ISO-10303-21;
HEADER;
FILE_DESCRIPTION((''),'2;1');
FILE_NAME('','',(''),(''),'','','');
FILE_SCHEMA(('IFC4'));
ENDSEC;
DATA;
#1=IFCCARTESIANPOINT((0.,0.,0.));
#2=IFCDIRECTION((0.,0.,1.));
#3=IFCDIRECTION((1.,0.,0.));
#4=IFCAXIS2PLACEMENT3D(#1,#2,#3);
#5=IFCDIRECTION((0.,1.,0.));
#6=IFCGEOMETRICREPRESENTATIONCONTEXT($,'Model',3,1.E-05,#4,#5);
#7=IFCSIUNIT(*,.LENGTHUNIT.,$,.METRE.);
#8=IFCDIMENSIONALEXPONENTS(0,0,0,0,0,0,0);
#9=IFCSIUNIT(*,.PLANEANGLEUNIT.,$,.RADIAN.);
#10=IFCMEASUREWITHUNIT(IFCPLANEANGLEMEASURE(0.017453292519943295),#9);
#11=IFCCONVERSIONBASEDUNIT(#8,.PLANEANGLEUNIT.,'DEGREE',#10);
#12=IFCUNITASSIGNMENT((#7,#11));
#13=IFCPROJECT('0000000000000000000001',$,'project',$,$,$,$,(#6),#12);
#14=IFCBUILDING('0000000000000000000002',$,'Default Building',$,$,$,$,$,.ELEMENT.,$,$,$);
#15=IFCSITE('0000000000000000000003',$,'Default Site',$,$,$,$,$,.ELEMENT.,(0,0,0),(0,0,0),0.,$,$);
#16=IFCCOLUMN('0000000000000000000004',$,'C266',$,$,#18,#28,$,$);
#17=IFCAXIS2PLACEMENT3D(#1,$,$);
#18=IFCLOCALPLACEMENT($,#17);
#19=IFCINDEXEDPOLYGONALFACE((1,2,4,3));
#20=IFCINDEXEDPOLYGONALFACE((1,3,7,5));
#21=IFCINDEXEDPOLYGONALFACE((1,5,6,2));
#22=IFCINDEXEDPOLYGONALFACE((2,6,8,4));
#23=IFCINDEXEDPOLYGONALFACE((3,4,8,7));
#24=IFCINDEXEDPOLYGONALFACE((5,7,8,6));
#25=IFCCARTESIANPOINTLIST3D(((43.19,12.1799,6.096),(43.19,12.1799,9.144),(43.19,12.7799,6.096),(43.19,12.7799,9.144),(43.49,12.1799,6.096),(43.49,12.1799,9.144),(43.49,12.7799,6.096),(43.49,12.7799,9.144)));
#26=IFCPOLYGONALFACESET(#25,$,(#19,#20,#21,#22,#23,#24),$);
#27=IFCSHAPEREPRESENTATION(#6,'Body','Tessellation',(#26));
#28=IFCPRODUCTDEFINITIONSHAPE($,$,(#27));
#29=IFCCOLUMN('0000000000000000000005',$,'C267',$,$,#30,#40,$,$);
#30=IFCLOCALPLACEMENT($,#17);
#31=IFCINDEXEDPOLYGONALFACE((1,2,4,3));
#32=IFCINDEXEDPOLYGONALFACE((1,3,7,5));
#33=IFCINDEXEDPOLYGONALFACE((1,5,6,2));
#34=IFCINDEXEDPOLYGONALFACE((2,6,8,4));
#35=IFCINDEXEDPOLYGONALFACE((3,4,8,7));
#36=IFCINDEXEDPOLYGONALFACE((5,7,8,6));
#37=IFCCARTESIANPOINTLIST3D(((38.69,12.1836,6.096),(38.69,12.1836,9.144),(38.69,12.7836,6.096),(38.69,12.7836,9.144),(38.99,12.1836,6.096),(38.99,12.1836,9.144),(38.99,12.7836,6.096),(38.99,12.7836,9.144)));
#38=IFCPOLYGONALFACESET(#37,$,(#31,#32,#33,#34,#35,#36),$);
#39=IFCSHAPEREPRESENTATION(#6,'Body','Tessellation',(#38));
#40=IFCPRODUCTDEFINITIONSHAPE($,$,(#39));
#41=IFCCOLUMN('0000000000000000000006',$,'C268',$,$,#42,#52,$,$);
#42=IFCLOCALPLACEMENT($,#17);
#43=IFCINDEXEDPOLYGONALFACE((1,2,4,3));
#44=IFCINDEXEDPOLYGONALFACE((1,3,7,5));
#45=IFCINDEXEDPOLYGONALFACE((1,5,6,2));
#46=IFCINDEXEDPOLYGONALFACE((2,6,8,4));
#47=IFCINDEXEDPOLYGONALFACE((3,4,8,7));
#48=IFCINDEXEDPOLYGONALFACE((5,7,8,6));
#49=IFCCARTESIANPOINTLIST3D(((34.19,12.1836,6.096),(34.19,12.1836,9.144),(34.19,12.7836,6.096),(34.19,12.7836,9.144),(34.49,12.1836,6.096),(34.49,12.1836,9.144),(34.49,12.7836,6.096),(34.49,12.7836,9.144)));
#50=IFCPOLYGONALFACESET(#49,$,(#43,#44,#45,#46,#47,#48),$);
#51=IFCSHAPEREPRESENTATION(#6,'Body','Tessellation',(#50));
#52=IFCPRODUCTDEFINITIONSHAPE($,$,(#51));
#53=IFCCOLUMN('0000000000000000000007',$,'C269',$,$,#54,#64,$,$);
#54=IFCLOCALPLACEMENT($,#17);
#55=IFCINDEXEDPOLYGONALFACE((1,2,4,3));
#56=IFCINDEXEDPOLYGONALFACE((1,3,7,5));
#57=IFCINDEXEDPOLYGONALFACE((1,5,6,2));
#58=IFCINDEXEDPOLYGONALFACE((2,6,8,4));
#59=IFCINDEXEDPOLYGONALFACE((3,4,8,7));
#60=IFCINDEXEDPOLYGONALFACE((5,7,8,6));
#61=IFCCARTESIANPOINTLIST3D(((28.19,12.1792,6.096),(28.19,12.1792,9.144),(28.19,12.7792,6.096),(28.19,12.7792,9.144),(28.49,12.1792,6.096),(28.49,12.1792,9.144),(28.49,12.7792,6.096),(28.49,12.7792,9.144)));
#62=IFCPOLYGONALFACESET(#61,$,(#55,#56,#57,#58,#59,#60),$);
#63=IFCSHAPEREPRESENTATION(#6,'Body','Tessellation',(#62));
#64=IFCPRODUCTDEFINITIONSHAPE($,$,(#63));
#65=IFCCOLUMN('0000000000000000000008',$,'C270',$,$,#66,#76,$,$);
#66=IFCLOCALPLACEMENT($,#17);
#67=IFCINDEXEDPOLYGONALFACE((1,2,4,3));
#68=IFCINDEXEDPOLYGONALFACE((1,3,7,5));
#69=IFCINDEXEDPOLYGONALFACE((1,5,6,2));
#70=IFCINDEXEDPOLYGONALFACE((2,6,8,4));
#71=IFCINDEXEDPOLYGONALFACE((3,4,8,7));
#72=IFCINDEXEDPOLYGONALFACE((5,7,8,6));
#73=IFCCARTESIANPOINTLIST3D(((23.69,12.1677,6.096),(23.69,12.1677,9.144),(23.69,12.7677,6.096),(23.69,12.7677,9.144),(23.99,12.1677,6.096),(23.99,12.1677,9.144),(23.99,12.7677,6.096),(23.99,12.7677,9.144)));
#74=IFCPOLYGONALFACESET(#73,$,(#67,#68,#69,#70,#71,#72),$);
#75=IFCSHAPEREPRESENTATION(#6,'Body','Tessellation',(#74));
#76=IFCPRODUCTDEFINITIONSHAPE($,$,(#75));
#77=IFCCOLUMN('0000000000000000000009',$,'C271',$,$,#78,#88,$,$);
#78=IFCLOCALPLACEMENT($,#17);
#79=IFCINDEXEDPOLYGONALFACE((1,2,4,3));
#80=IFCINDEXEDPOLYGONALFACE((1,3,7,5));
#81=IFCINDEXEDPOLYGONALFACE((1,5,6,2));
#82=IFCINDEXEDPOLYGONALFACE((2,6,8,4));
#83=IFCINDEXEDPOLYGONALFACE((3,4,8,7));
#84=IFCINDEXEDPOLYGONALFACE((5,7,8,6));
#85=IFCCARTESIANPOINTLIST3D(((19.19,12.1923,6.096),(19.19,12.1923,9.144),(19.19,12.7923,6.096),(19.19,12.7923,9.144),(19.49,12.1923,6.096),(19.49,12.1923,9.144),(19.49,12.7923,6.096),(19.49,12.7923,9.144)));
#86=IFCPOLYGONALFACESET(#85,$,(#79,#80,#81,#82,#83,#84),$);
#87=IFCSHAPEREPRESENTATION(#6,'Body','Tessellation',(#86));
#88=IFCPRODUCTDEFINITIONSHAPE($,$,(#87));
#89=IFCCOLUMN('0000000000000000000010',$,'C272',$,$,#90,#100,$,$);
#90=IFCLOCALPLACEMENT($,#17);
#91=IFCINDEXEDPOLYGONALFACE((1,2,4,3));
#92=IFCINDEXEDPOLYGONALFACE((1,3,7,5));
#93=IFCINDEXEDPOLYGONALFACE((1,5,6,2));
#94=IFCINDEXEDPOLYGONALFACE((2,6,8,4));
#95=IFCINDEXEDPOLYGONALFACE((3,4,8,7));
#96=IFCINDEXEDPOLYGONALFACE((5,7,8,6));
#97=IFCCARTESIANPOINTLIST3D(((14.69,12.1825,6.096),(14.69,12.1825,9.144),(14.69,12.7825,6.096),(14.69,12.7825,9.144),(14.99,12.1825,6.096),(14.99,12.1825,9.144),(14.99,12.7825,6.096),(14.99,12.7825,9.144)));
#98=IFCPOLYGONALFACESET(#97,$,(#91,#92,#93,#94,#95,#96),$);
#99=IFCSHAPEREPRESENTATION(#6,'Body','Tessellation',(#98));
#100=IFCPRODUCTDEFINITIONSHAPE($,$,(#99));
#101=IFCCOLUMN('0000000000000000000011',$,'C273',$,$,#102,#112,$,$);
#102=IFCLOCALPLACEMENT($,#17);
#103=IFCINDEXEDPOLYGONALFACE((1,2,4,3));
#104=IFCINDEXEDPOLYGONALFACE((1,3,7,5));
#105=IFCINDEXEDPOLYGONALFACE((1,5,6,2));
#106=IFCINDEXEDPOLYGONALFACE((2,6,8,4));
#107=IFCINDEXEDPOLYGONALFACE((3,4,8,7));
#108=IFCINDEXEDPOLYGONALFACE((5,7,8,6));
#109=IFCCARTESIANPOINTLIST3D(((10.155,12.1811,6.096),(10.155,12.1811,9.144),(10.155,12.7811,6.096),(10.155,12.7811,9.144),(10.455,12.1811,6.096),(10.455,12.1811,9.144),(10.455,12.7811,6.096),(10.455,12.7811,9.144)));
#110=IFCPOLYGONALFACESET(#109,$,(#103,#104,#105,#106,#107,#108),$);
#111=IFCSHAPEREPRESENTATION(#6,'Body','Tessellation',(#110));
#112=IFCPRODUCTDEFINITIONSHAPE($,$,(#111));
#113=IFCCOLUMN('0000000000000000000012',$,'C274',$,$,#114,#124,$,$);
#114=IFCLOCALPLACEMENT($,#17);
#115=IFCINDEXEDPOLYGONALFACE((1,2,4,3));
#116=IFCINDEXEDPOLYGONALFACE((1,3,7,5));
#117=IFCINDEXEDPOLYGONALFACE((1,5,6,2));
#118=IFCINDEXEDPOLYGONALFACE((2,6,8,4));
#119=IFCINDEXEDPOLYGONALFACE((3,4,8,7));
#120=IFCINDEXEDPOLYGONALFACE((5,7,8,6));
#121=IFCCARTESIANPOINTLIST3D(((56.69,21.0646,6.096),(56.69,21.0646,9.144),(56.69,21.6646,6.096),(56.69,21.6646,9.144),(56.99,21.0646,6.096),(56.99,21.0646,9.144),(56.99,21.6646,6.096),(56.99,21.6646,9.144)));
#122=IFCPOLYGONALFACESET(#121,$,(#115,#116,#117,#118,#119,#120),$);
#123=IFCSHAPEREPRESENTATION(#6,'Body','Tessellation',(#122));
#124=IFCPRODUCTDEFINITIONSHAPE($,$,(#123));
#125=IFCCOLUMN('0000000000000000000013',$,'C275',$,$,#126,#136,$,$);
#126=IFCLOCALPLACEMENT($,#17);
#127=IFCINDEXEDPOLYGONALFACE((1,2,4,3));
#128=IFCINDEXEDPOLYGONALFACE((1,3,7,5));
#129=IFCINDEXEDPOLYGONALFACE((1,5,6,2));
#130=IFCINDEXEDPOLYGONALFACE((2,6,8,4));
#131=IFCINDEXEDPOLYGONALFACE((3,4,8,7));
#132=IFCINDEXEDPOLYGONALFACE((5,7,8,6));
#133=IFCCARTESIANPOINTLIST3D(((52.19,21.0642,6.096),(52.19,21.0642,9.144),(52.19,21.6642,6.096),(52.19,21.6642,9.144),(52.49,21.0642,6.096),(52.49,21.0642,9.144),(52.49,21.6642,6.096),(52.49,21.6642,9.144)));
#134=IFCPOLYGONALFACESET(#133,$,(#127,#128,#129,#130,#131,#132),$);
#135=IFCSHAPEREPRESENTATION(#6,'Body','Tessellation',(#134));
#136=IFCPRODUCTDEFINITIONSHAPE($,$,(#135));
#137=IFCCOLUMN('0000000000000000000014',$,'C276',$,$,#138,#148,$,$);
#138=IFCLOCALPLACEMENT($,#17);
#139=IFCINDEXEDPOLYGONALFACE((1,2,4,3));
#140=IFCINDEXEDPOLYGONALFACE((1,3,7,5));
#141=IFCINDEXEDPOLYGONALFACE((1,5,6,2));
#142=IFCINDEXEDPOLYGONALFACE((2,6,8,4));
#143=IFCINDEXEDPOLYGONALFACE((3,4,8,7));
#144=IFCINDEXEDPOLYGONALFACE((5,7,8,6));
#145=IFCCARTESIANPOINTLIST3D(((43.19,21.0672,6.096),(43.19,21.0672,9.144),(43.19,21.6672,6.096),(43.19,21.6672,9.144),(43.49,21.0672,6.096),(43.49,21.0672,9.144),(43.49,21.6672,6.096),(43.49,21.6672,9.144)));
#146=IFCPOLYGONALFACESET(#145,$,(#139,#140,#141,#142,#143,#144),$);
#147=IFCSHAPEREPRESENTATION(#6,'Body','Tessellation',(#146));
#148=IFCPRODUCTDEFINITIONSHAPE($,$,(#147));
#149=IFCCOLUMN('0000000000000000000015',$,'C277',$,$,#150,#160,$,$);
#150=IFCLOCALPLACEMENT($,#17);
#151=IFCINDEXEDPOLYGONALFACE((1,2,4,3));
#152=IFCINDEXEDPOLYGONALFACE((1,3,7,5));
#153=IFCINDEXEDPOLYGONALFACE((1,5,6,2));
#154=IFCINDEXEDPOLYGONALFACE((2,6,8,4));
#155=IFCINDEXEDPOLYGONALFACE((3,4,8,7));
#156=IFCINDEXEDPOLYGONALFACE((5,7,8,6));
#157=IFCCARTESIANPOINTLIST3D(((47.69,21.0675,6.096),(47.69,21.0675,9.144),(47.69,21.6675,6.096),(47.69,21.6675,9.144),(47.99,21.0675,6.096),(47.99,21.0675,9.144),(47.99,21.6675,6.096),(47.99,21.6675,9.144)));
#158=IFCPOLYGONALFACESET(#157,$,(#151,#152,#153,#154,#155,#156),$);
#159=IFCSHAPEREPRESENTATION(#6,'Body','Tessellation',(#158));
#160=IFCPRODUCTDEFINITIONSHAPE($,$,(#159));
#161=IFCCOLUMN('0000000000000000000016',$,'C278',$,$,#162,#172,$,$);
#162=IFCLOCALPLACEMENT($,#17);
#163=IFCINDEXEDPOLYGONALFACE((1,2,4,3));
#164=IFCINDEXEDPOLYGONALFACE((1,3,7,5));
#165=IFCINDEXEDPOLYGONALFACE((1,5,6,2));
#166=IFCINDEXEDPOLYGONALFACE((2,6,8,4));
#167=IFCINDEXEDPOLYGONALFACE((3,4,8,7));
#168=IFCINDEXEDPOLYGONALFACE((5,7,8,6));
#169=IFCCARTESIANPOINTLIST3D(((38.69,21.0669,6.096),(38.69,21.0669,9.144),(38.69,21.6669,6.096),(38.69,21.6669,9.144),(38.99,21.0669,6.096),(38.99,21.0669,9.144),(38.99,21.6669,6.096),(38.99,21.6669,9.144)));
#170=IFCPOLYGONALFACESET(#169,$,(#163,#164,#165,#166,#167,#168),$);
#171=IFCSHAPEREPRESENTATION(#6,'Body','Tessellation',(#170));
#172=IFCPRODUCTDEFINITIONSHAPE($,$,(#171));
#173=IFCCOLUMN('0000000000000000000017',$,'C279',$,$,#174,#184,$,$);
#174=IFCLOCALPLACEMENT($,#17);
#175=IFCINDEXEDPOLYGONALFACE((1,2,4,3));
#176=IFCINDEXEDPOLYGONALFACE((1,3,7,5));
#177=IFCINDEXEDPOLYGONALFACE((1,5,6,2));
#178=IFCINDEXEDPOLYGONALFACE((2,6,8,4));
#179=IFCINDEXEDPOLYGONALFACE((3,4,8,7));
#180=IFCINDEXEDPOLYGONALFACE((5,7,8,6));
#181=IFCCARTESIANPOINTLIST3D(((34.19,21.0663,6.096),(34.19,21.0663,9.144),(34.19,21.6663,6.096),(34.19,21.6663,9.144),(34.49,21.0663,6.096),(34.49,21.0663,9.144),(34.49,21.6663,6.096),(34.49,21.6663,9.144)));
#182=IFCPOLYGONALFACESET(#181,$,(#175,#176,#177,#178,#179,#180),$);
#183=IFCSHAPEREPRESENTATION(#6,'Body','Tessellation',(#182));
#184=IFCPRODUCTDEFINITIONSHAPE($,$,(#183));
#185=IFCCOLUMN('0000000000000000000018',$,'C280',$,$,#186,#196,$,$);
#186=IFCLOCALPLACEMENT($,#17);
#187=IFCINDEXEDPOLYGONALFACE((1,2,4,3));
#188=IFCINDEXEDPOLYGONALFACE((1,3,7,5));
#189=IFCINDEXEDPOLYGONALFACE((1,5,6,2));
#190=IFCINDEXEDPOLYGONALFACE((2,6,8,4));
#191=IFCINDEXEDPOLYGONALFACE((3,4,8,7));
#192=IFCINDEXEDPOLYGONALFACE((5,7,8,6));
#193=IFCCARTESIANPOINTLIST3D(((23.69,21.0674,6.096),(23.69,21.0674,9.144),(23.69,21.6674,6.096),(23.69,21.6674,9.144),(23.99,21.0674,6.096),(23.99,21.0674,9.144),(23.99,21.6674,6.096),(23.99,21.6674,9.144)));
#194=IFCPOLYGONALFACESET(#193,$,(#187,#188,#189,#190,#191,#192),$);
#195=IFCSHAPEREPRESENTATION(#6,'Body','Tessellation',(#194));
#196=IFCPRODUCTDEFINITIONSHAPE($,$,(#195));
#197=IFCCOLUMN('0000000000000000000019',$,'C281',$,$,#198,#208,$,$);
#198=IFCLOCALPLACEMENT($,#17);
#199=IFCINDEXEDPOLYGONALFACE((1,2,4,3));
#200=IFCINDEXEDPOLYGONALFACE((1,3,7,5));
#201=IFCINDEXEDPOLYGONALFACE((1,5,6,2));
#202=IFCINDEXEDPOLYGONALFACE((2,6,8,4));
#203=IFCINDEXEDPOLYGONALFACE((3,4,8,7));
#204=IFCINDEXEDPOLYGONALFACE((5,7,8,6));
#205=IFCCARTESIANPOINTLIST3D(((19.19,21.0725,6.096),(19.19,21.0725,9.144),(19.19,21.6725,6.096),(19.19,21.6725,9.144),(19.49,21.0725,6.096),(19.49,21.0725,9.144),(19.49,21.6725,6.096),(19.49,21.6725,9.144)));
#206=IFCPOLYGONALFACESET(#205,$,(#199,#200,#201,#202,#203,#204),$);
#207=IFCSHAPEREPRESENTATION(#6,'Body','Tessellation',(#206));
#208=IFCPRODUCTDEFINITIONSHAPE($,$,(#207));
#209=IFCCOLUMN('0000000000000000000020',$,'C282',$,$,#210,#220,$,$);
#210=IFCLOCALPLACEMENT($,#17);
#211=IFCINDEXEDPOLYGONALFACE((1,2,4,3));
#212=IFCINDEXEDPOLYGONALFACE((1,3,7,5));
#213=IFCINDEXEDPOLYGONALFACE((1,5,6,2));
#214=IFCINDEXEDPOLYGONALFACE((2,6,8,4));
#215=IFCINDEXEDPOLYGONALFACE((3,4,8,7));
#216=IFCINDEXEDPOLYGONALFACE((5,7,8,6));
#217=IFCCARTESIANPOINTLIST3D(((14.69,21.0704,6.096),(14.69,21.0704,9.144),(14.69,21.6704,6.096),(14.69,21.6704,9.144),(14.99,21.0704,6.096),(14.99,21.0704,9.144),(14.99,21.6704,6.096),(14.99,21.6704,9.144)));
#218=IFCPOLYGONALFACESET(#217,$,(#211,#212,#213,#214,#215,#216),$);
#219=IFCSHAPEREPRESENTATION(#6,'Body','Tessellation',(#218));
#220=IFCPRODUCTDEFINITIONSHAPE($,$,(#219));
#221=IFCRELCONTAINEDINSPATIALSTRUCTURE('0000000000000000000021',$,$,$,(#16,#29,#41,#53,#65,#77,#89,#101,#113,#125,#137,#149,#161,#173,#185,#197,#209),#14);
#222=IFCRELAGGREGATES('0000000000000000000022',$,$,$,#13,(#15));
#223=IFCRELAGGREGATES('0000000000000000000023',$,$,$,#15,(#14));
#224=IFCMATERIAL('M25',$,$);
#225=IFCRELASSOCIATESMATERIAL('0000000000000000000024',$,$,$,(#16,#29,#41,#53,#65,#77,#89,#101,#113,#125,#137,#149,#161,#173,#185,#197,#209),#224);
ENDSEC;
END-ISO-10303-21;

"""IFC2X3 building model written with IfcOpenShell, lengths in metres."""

from ifc_helpers import new_model, entity, si_unit, converted_unit, direction, frame, frame_2d, origin_with_axes, place, context, project, spatial, rectangle, extrude, material, element, save


model = new_model("IFC2X3")

# Units and contexts
model_context = context("Model", 3, precision=1e-05, world=origin_with_axes(), true_north=direction((0.0, 1.0, 0.0)))
ifc_project = project(units=[si_unit("LENGTHUNIT", "METRE"), converted_unit("PLANEANGLEUNIT", "DEGREE", entity("IfcPlaneAngleMeasure", 0.017453292519943295), si_unit("PLANEANGLEUNIT", "RADIAN"), dimensions=[0, 0, 0, 0, 0, 0, 0])], contexts=[model_context])

# Site, building
site = spatial("IfcSite", under=ifc_project, Name="Default Site", CompositionType="ELEMENT", RefLatitude=(0, 0, 0), RefLongitude=(0, 0, 0), RefElevation=0.0)
building = spatial("IfcBuilding", under=site, Name="Default Building", CompositionType="ELEMENT")

# Columns
ifc_material = material(Name="M25")
placement = place(None, origin_with_axes())
element("IfcColumn", 1, at=placement, inside=building, material=ifc_material, Name="C266", context=model_context, shape_type="SweptSolid", body=[
    extrude(rectangle(XDim=0.3, YDim=0.6, at=frame_2d((0.0, 0.0), x_axis=(1.0, 0.0, 0.0))), frame((43.34, 12.4799, 6.096), z_axis=(0.0, 0.0, 1.0), x_axis=(1.0, 0.0, 0.0)), (0.0, 0.0, 1.0), 3.048),
])
element("IfcColumn", 2, at=placement, inside=building, material=ifc_material, Name="C267", context=model_context, shape_type="SweptSolid", body=[
    extrude(rectangle(XDim=0.3, YDim=0.6, at=frame_2d((0.0, 0.0), x_axis=(1.0, 0.0, 0.0))), frame((38.84, 12.4836, 6.096), z_axis=(0.0, 0.0, 1.0), x_axis=(1.0, 0.0, 0.0)), (0.0, 0.0, 1.0), 3.048),
])
element("IfcColumn", 3, at=placement, inside=building, material=ifc_material, Name="C268", context=model_context, shape_type="SweptSolid", body=[
    extrude(rectangle(XDim=0.3, YDim=0.6, at=frame_2d((0.0, 0.0), x_axis=(1.0, 0.0, 0.0))), frame((34.34, 12.4836, 6.096), z_axis=(0.0, 0.0, 1.0), x_axis=(1.0, 0.0, 0.0)), (0.0, 0.0, 1.0), 3.048),
])
element("IfcColumn", 4, at=placement, inside=building, material=ifc_material, Name="C269", context=model_context, shape_type="SweptSolid", body=[
    extrude(rectangle(XDim=0.3, YDim=0.6, at=frame_2d((0.0, 0.0), x_axis=(1.0, 0.0, 0.0))), frame((28.34, 12.4792, 6.096), z_axis=(0.0, 0.0, 1.0), x_axis=(1.0, 0.0, 0.0)), (0.0, 0.0, 1.0), 3.048),
])
element("IfcColumn", 5, at=placement, inside=building, material=ifc_material, Name="C270", context=model_context, shape_type="SweptSolid", body=[
    extrude(rectangle(XDim=0.3, YDim=0.6, at=frame_2d((0.0, 0.0), x_axis=(1.0, 0.0, 0.0))), frame((23.84, 12.4677, 6.096), z_axis=(0.0, 0.0, 1.0), x_axis=(1.0, 0.0, 0.0)), (0.0, 0.0, 1.0), 3.048),
])
element("IfcColumn", 6, at=placement, inside=building, material=ifc_material, Name="C271", context=model_context, shape_type="SweptSolid", body=[
    extrude(rectangle(XDim=0.3, YDim=0.6, at=frame_2d((0.0, 0.0), x_axis=(1.0, 0.0, 0.0))), frame((19.34, 12.4923, 6.096), z_axis=(0.0, 0.0, 1.0), x_axis=(1.0, 0.0, 0.0)), (0.0, 0.0, 1.0), 3.048),
])
element("IfcColumn", 7, at=placement, inside=building, material=ifc_material, Name="C272", context=model_context, shape_type="SweptSolid", body=[
    extrude(rectangle(XDim=0.3, YDim=0.6, at=frame_2d((0.0, 0.0), x_axis=(1.0, 0.0, 0.0))), frame((14.84, 12.4825, 6.096), z_axis=(0.0, 0.0, 1.0), x_axis=(1.0, 0.0, 0.0)), (0.0, 0.0, 1.0), 3.048),
])
element("IfcColumn", 8, at=placement, inside=building, material=ifc_material, Name="C273", context=model_context, shape_type="SweptSolid", body=[
    extrude(rectangle(XDim=0.3, YDim=0.6, at=frame_2d((0.0, 0.0), x_axis=(1.0, 0.0, 0.0))), frame((10.305, 12.4811, 6.096), z_axis=(0.0, 0.0, 1.0), x_axis=(1.0, 0.0, 0.0)), (0.0, 0.0, 1.0), 3.048),
])
element("IfcColumn", 9, at=placement, inside=building, material=ifc_material, Name="C274", context=model_context, shape_type="SweptSolid", body=[
    extrude(rectangle(XDim=0.3, YDim=0.6, at=frame_2d((0.0, 0.0), x_axis=(1.0, 0.0, 0.0))), frame((56.84, 21.3646, 6.096), z_axis=(0.0, 0.0, 1.0), x_axis=(1.0, 0.0, 0.0)), (0.0, 0.0, 1.0), 3.048),
])
element("IfcColumn", 10, at=placement, inside=building, material=ifc_material, Name="C275", context=model_context, shape_type="SweptSolid", body=[
    extrude(rectangle(XDim=0.3, YDim=0.6, at=frame_2d((0.0, 0.0), x_axis=(1.0, 0.0, 0.0))), frame((52.34, 21.3642, 6.096), z_axis=(0.0, 0.0, 1.0), x_axis=(1.0, 0.0, 0.0)), (0.0, 0.0, 1.0), 3.048),
])
element("IfcColumn", 11, at=placement, inside=building, material=ifc_material, Name="C276", context=model_context, shape_type="SweptSolid", body=[
    extrude(rectangle(XDim=0.3, YDim=0.6, at=frame_2d((0.0, 0.0), x_axis=(1.0, 0.0, 0.0))), frame((43.34, 21.3672, 6.096), z_axis=(0.0, 0.0, 1.0), x_axis=(1.0, 0.0, 0.0)), (0.0, 0.0, 1.0), 3.048),
])
element("IfcColumn", 12, at=placement, inside=building, material=ifc_material, Name="C277", context=model_context, shape_type="SweptSolid", body=[
    extrude(rectangle(XDim=0.3, YDim=0.6, at=frame_2d((0.0, 0.0), x_axis=(1.0, 0.0, 0.0))), frame((47.84, 21.3675, 6.096), z_axis=(0.0, 0.0, 1.0), x_axis=(1.0, 0.0, 0.0)), (0.0, 0.0, 1.0), 3.048),
])
element("IfcColumn", 13, at=placement, inside=building, material=ifc_material, Name="C278", context=model_context, shape_type="SweptSolid", body=[
    extrude(rectangle(XDim=0.3, YDim=0.6, at=frame_2d((0.0, 0.0), x_axis=(1.0, 0.0, 0.0))), frame((38.84, 21.3669, 6.096), z_axis=(0.0, 0.0, 1.0), x_axis=(1.0, 0.0, 0.0)), (0.0, 0.0, 1.0), 3.048),
])
element("IfcColumn", 14, at=placement, inside=building, material=ifc_material, Name="C279", context=model_context, shape_type="SweptSolid", body=[
    extrude(rectangle(XDim=0.3, YDim=0.6, at=frame_2d((0.0, 0.0), x_axis=(1.0, 0.0, 0.0))), frame((34.34, 21.3663, 6.096), z_axis=(0.0, 0.0, 1.0), x_axis=(1.0, 0.0, 0.0)), (0.0, 0.0, 1.0), 3.048),
])
element("IfcColumn", 15, at=placement, inside=building, material=ifc_material, Name="C280", context=model_context, shape_type="SweptSolid", body=[
    extrude(rectangle(XDim=0.3, YDim=0.6, at=frame_2d((0.0, 0.0), x_axis=(1.0, 0.0, 0.0))), frame((23.84, 21.3674, 6.096), z_axis=(0.0, 0.0, 1.0), x_axis=(1.0, 0.0, 0.0)), (0.0, 0.0, 1.0), 3.048),
])
element("IfcColumn", 16, at=placement, inside=building, material=ifc_material, Name="C281", context=model_context, shape_type="SweptSolid", body=[
    extrude(rectangle(XDim=0.3, YDim=0.6, at=frame_2d((0.0, 0.0), x_axis=(1.0, 0.0, 0.0))), frame((19.34, 21.3725, 6.096), z_axis=(0.0, 0.0, 1.0), x_axis=(1.0, 0.0, 0.0)), (0.0, 0.0, 1.0), 3.048),
])
element("IfcColumn", 17, at=placement, inside=building, material=ifc_material, Name="C282", context=model_context, shape_type="SweptSolid", body=[
    extrude(rectangle(XDim=0.3, YDim=0.6, at=frame_2d((0.0, 0.0), x_axis=(1.0, 0.0, 0.0))), frame((14.84, 21.3704, 6.096), z_axis=(0.0, 0.0, 1.0), x_axis=(1.0, 0.0, 0.0)), (0.0, 0.0, 1.0), 3.048),
])

save(model, "model.ifc")
